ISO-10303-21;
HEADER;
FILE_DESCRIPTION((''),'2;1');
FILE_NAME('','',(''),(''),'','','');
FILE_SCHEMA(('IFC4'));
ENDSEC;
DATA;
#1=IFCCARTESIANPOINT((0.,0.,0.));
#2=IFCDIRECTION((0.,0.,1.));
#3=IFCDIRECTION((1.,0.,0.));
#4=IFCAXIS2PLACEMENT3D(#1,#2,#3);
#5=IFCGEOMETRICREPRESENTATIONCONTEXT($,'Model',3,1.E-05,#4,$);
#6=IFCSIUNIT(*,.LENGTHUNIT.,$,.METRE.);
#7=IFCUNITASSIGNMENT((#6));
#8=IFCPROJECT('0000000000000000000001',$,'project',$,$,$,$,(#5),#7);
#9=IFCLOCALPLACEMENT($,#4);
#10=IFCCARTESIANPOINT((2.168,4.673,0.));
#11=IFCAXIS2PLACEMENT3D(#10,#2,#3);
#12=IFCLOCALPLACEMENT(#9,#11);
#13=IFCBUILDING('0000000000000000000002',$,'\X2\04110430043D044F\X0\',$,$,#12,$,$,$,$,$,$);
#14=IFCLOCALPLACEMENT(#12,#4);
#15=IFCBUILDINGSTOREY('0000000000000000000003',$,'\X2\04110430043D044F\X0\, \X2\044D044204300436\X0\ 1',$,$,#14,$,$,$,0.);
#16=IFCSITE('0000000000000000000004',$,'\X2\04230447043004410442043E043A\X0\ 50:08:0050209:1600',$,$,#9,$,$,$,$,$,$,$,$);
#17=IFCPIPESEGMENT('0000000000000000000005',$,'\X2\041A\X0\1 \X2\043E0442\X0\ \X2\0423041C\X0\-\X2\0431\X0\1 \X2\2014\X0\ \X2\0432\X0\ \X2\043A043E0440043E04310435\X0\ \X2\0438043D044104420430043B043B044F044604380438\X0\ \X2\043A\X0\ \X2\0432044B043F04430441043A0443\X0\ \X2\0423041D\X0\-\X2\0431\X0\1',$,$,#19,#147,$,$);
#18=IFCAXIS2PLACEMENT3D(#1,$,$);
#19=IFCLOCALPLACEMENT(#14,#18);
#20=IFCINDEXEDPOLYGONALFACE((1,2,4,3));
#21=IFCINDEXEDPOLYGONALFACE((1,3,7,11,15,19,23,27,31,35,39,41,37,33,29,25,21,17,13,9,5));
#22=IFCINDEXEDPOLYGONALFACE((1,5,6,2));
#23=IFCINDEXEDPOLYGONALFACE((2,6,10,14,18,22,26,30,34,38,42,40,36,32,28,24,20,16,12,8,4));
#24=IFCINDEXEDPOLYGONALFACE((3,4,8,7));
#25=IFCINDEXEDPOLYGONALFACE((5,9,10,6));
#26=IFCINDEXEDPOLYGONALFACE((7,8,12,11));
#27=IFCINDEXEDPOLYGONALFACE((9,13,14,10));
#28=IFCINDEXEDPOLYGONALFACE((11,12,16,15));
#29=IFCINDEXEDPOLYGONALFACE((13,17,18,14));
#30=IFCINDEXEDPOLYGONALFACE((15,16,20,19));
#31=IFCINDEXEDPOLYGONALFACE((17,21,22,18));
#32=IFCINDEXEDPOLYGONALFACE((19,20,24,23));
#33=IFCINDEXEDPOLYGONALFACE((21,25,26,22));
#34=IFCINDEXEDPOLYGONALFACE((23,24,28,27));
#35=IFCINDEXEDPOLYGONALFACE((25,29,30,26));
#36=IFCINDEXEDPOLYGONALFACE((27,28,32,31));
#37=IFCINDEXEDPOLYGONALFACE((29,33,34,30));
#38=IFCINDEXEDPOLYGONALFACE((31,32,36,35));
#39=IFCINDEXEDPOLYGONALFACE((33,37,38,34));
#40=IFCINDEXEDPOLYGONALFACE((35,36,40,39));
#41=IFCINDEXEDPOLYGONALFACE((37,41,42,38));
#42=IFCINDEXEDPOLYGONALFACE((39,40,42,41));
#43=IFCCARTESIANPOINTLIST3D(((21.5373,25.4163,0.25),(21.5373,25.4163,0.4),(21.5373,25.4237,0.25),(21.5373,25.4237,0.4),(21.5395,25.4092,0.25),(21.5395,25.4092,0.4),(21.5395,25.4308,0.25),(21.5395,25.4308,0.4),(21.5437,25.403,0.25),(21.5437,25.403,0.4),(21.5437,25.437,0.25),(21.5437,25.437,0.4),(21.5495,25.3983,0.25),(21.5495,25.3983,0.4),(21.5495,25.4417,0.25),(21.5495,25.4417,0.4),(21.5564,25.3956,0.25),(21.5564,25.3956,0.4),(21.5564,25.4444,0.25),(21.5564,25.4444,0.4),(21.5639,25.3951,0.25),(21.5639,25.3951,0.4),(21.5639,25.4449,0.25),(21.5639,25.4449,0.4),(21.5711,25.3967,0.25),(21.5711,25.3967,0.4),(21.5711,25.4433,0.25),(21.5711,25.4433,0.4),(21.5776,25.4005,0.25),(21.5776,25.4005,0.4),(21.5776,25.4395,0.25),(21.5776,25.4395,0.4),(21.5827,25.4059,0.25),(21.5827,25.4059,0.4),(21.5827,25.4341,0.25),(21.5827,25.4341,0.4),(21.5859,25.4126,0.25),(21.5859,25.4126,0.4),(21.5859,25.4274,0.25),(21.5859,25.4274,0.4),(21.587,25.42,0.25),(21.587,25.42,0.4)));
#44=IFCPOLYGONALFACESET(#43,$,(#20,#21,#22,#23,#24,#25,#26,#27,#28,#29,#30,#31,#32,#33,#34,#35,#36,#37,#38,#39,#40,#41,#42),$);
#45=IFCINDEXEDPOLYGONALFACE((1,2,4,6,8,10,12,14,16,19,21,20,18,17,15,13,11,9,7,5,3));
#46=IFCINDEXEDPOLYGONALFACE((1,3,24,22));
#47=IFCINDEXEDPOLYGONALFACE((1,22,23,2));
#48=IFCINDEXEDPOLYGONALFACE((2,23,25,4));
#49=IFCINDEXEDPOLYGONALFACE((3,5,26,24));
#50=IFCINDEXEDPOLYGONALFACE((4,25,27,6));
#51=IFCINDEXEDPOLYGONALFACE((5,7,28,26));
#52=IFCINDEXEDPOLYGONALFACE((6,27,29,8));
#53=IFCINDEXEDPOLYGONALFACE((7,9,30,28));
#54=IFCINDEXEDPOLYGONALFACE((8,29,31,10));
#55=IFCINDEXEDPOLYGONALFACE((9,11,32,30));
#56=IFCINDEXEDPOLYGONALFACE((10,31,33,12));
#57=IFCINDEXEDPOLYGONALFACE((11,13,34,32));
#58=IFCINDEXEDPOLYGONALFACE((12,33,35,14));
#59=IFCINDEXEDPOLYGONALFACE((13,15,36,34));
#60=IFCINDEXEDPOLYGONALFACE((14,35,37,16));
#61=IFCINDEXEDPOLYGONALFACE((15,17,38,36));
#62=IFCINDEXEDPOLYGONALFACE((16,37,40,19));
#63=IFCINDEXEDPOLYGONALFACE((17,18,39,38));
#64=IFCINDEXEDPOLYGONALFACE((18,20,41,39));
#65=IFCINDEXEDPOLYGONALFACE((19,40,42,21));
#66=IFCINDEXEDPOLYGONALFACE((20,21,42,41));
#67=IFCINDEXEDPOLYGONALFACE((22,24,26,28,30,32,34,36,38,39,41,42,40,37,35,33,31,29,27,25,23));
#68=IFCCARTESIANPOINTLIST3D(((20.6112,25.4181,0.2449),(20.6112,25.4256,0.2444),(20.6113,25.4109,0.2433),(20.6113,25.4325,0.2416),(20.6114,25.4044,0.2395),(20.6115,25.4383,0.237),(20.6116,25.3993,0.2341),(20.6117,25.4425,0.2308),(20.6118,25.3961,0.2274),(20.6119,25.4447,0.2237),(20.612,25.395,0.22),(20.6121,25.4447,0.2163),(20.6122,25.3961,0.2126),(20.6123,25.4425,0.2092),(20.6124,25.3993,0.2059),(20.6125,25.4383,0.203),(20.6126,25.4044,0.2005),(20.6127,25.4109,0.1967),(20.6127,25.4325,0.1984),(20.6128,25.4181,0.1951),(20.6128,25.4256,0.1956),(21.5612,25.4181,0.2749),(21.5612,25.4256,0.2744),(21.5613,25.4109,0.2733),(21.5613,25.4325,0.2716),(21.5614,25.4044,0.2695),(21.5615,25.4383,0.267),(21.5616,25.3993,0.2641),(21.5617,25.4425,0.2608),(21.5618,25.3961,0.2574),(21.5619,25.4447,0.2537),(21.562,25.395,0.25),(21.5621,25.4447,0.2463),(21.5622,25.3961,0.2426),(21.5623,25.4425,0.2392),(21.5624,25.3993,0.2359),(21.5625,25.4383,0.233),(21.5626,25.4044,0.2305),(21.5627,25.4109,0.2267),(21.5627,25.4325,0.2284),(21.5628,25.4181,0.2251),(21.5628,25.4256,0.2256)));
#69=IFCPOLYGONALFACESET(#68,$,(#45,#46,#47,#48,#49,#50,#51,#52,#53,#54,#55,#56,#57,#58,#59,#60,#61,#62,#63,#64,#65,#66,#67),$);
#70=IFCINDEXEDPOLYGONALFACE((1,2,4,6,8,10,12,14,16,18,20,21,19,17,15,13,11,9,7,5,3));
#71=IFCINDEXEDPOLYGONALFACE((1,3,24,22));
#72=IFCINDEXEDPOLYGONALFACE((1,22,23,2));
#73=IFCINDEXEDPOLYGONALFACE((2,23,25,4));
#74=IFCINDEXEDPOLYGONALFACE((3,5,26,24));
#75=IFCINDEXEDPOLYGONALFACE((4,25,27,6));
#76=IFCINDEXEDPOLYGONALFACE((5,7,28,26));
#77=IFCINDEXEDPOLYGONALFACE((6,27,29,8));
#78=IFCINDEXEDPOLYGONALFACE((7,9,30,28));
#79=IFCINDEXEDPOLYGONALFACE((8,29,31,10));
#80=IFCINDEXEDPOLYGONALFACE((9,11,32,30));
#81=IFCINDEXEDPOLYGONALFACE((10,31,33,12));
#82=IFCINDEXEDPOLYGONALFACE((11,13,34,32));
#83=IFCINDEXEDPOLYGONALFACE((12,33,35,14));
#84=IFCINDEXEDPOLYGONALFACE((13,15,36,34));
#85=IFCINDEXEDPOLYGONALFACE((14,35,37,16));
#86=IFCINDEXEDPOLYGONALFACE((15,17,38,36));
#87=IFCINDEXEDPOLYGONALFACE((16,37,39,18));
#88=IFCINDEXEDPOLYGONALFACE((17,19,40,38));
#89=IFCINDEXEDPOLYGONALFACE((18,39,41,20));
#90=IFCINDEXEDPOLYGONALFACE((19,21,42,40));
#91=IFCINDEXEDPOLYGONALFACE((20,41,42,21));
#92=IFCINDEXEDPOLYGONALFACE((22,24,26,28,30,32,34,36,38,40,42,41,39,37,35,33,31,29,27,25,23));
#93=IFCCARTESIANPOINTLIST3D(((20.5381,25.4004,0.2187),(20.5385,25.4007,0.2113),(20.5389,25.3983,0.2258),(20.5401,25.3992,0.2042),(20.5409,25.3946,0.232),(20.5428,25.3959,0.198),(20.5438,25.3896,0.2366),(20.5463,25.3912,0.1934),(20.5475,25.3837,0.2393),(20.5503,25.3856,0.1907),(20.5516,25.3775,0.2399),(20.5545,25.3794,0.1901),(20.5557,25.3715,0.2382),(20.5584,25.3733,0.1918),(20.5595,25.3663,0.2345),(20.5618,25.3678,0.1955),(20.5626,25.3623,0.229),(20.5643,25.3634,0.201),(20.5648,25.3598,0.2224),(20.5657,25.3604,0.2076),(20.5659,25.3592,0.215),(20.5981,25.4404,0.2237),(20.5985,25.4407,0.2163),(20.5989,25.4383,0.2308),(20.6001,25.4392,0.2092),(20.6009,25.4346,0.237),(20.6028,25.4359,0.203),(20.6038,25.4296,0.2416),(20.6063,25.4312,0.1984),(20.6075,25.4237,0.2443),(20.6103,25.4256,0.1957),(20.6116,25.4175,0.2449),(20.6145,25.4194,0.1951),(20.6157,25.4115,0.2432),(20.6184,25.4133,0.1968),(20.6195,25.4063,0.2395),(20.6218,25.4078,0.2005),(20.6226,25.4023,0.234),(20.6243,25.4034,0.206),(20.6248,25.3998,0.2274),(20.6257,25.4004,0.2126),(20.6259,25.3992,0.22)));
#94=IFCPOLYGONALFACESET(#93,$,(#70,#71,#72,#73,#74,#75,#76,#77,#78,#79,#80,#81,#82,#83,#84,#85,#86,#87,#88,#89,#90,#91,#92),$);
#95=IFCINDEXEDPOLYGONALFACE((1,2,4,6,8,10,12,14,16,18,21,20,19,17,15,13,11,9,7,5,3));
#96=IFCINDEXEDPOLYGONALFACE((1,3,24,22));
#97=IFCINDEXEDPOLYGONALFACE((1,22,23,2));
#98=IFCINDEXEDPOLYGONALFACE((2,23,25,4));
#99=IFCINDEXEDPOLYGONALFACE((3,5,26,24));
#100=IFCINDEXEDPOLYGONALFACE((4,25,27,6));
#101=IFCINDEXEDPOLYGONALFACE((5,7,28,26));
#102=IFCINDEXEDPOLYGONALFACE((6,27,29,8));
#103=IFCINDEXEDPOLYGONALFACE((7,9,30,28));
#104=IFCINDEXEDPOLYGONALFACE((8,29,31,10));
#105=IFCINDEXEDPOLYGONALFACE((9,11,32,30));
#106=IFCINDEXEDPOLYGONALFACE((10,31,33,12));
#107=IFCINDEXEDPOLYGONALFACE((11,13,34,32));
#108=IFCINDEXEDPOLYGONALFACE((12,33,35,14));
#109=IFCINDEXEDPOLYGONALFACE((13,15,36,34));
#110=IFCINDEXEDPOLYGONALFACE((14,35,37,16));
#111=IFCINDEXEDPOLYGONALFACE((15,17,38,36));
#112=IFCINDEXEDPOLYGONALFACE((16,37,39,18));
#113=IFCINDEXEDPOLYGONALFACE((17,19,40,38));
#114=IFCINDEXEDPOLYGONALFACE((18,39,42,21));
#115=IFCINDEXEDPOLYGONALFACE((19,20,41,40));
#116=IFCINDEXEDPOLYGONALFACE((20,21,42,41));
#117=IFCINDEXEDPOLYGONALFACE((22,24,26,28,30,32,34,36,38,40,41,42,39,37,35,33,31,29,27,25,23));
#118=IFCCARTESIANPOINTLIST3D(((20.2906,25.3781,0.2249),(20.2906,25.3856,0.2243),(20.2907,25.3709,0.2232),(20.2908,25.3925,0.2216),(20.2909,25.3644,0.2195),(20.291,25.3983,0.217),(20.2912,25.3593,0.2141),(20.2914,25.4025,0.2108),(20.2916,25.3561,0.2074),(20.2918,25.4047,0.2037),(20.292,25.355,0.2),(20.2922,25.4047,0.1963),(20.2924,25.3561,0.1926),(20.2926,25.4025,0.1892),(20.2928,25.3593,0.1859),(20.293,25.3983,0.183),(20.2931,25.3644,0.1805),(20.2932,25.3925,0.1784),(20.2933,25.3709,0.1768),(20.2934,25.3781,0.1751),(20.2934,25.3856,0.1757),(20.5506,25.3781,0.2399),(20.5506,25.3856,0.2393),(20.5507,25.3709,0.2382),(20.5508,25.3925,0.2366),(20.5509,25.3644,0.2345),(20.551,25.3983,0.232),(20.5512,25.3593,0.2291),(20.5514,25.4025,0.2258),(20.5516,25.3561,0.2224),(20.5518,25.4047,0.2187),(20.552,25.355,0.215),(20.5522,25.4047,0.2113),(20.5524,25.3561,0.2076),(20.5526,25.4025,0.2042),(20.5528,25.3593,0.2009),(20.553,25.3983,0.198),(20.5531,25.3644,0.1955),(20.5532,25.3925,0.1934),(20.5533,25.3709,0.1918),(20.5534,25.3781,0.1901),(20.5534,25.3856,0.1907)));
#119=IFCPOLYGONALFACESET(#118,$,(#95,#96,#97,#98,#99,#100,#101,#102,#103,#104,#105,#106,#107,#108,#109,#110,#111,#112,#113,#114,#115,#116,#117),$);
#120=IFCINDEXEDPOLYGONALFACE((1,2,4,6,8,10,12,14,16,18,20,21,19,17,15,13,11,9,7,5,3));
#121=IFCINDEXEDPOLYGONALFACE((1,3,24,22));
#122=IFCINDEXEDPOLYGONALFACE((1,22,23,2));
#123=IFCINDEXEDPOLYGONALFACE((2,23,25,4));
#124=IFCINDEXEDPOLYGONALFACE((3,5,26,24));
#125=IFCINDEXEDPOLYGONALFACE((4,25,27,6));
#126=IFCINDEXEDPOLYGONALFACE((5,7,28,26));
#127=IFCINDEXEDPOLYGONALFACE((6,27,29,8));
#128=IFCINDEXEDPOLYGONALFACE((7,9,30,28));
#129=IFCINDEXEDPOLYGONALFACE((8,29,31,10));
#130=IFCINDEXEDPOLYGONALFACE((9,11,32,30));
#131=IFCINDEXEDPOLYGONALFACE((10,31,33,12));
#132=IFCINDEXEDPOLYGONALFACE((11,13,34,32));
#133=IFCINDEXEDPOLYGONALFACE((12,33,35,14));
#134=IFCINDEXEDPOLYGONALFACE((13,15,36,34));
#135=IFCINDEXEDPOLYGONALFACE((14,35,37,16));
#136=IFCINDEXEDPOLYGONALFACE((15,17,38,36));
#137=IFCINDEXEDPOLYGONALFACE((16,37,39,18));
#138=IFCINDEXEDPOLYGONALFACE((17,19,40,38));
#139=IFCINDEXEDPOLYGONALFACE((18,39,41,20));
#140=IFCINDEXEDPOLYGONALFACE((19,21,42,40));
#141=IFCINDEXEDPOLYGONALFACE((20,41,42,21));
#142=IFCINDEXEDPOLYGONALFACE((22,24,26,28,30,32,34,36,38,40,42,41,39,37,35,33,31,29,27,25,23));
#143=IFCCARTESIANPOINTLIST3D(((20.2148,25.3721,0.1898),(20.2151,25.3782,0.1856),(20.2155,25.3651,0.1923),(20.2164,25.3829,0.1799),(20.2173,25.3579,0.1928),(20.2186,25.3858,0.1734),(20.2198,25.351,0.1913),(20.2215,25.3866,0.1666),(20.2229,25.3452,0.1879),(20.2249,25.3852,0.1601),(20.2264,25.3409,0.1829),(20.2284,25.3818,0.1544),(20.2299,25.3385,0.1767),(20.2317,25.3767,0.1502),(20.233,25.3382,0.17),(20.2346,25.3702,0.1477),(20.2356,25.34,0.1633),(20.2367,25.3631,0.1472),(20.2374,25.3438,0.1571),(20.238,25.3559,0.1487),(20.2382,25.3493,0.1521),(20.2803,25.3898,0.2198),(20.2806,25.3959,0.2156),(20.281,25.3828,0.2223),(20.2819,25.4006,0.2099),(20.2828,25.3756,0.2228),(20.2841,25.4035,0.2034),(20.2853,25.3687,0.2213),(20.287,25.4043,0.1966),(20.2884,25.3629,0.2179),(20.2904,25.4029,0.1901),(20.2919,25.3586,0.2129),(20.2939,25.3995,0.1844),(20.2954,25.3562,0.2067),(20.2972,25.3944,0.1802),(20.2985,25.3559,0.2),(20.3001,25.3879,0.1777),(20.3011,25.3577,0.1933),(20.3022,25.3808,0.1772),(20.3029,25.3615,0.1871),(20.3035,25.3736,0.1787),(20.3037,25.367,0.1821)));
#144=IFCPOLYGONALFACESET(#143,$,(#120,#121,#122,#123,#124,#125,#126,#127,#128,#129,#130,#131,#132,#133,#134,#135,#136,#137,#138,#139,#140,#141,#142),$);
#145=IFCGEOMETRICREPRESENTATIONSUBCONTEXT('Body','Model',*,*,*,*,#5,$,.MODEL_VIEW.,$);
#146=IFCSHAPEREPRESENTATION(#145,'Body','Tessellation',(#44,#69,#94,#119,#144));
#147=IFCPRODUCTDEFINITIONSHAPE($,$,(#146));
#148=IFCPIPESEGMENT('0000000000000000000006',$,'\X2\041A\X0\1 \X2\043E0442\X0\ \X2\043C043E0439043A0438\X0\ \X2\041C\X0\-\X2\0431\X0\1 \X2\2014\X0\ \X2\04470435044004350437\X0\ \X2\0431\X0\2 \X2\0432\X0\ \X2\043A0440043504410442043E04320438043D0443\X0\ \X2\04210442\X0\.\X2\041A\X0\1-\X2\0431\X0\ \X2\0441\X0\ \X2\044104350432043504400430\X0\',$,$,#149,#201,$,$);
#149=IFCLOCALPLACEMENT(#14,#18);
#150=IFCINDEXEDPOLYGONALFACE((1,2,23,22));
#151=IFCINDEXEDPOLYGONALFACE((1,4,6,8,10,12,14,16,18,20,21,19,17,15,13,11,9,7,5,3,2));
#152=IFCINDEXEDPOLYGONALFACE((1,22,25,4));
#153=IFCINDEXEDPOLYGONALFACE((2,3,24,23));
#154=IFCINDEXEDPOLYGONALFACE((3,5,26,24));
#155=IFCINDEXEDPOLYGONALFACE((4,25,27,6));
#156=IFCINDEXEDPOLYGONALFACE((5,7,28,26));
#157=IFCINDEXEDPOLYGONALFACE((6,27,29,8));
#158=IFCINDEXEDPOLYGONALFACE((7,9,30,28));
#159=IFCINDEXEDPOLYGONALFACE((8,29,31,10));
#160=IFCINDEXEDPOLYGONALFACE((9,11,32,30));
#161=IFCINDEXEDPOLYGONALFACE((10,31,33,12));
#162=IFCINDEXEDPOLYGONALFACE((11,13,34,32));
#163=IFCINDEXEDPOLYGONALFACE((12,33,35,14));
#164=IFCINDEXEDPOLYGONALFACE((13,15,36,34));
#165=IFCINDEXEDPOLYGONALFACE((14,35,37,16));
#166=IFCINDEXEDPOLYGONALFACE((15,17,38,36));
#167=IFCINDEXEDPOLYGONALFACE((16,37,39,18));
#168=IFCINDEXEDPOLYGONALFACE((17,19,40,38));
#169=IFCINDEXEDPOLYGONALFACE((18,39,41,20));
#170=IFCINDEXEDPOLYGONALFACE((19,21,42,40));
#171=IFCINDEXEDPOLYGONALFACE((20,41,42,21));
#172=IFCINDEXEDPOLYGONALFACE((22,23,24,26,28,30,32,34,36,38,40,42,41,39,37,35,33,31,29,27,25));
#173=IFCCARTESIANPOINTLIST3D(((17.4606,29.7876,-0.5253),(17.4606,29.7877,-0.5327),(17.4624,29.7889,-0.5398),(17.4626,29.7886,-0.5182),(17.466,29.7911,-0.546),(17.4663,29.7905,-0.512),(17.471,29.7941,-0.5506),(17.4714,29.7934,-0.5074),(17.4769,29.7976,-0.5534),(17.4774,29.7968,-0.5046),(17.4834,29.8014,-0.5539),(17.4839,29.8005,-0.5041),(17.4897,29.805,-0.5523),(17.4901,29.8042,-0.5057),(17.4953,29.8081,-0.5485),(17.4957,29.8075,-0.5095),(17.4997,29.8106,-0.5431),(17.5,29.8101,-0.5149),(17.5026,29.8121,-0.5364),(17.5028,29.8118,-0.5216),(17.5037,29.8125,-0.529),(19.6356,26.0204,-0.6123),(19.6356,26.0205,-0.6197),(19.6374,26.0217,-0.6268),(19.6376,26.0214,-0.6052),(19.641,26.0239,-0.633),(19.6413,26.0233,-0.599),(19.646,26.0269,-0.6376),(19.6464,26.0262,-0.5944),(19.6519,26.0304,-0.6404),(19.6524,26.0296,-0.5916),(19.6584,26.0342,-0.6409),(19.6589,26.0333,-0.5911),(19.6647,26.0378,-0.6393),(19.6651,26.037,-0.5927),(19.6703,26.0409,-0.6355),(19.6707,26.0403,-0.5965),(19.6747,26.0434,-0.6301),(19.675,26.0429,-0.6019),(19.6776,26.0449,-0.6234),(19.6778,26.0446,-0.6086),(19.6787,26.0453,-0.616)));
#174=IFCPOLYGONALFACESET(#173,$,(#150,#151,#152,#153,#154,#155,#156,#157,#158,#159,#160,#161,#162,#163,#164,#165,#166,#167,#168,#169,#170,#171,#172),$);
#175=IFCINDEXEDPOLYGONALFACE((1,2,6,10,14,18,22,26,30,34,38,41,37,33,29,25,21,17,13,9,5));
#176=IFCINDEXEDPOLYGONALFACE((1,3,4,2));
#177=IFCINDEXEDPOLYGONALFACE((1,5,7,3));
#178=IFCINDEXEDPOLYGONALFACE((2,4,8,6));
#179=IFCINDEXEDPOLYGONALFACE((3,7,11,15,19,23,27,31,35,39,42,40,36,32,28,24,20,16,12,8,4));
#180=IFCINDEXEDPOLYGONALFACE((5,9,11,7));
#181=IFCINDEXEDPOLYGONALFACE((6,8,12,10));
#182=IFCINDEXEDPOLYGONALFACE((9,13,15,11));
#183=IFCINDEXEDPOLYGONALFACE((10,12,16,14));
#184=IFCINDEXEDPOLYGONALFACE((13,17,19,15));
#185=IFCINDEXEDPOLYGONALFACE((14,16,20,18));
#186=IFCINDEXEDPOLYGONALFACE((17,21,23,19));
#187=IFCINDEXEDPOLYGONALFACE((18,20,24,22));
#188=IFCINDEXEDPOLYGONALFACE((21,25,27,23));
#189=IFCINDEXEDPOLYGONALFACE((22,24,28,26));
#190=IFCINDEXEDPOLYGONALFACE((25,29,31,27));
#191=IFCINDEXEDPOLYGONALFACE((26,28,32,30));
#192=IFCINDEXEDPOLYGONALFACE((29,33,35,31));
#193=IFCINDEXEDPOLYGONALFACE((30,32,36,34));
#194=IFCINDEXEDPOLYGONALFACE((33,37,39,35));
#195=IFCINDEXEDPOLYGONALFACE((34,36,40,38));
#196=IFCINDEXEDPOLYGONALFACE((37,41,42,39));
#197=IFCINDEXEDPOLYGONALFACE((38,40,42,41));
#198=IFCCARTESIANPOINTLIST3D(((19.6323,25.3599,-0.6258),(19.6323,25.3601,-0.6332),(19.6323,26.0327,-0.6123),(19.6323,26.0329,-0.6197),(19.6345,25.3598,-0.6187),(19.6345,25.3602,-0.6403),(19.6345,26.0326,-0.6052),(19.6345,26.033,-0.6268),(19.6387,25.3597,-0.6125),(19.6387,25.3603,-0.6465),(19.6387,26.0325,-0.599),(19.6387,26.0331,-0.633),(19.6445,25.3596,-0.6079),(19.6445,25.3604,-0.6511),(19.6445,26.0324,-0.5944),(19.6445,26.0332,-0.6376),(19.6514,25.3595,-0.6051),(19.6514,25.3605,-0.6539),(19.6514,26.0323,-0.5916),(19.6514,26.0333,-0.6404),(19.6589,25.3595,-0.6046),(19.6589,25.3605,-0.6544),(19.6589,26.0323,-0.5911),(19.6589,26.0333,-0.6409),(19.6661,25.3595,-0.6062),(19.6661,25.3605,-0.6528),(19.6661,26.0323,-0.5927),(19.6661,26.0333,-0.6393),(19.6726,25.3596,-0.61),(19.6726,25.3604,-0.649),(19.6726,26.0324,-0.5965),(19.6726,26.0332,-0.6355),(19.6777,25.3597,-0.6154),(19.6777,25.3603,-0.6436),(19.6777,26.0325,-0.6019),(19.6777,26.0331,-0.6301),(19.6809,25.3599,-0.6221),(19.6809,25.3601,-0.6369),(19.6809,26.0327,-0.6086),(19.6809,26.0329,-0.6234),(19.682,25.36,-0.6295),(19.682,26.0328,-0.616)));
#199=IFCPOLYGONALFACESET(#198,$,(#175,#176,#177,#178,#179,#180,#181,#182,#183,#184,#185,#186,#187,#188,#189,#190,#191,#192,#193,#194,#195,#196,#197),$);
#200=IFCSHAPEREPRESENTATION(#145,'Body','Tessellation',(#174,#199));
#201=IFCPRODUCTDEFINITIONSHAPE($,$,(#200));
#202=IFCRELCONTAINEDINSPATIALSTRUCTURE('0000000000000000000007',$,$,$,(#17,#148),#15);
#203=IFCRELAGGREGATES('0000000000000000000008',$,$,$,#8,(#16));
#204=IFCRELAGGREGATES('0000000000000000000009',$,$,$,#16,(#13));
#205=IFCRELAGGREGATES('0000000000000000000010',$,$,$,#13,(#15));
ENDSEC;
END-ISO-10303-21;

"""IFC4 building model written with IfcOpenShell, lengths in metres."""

from ifc_helpers import new_model, si_unit, frame, origin_with_axes, origin_2d, place, context, subcontext, project, spatial, circle, extrude, element, save


model = new_model("IFC4")

# Units and contexts
model_context = context("Model", 3, precision=1e-05, world=origin_with_axes())
body_context = subcontext(model_context, "Body", "Model", "MODEL_VIEW")
ifc_project = project(units=[si_unit("LENGTHUNIT", "METRE")], contexts=[model_context])

# Site, building, storey
site_placement = place(None, origin_with_axes())
site = spatial("IfcSite", under=ifc_project, at=site_placement, Name="Участок 50:08:0050209:1600")
building_placement = place(site_placement, frame((2.168, 4.673, 0.0), z_axis=(0.0, 0.0, 1.0), x_axis=(1.0, 0.0, 0.0)))
building = spatial("IfcBuilding", under=site, at=building_placement, Name="Баня")
storey_placement = place(building_placement, origin_with_axes())
storey = spatial("IfcBuildingStorey", under=building, at=storey_placement, Name="Баня, этаж 1", Elevation=0.0)

# Pipe segments
pipe_segment_1_placement = place(storey_placement, origin_with_axes())
element("IfcPipeSegment", 1, at=pipe_segment_1_placement, inside=storey, Name="К1 от УМ-б1 — в коробе инсталляции к выпуску УН-б1", context=body_context, shape_type="SweptSolid", body=[
    extrude(circle(Radius=0.025, at=origin_2d()), frame((21.562, 25.42, 0.4), z_axis=(0.0, 0.0, -1.0), x_axis=(1.0, 0.0, 0.0)), (0.0, 0.0, 1.0), 0.15),
    extrude(circle(Radius=0.025, at=origin_2d()), frame((21.562, 25.42, 0.25), z_axis=(-0.999502, 0.0, -0.031563), x_axis=(0.0, -1.0, 0.0)), (0.0, 0.0, 1.0), 0.9505),
    extrude(circle(Radius=0.025, at=origin_2d()), frame((20.612, 25.42, 0.22), z_axis=(-0.830057, -0.553372, -0.069171), x_axis=(0.5547, -0.83205, 0.0)), (0.0, 0.0, 1.0), 0.0723),
    extrude(circle(Radius=0.025, at=origin_2d()), frame((20.552, 25.38, 0.215), z_axis=(-0.99834, 0.0, -0.057597), x_axis=(0.0, -1.0, 0.0)), (0.0, 0.0, 1.0), 0.2604),
    extrude(circle(Radius=0.025, at=origin_2d()), frame((20.292, 25.38, 0.2), z_axis=(-0.882918, -0.23859, -0.40439), x_axis=(0.260872, -0.965373, 0.0)), (0.0, 0.0, 1.0), 0.0742),
])
pipe_segment_2_placement = place(storey_placement, origin_with_axes())
element("IfcPipeSegment", 2, at=pipe_segment_2_placement, inside=storey, Name="К1 от мойки М-б1 — через б2 в крестовину Ст.К1-б с севера", context=body_context, shape_type="SweptSolid", body=[
    extrude(circle(Radius=0.025, at=origin_2d()), frame((17.482, 29.8, -0.529), z_axis=(0.499901, -0.865852, -0.019996), x_axis=(0.866025, 0.500001, 0.0)), (0.0, 0.0, 1.0), 4.3509),
    extrude(circle(Radius=0.025, at=origin_2d()), frame((19.657, 26.0328, -0.616), z_axis=(0.0, -0.999799, -0.020061), x_axis=(1.0, 0.0, 0.0)), (0.0, 0.0, 1.0), 0.6729),
])

save(model, "model.ifc")
